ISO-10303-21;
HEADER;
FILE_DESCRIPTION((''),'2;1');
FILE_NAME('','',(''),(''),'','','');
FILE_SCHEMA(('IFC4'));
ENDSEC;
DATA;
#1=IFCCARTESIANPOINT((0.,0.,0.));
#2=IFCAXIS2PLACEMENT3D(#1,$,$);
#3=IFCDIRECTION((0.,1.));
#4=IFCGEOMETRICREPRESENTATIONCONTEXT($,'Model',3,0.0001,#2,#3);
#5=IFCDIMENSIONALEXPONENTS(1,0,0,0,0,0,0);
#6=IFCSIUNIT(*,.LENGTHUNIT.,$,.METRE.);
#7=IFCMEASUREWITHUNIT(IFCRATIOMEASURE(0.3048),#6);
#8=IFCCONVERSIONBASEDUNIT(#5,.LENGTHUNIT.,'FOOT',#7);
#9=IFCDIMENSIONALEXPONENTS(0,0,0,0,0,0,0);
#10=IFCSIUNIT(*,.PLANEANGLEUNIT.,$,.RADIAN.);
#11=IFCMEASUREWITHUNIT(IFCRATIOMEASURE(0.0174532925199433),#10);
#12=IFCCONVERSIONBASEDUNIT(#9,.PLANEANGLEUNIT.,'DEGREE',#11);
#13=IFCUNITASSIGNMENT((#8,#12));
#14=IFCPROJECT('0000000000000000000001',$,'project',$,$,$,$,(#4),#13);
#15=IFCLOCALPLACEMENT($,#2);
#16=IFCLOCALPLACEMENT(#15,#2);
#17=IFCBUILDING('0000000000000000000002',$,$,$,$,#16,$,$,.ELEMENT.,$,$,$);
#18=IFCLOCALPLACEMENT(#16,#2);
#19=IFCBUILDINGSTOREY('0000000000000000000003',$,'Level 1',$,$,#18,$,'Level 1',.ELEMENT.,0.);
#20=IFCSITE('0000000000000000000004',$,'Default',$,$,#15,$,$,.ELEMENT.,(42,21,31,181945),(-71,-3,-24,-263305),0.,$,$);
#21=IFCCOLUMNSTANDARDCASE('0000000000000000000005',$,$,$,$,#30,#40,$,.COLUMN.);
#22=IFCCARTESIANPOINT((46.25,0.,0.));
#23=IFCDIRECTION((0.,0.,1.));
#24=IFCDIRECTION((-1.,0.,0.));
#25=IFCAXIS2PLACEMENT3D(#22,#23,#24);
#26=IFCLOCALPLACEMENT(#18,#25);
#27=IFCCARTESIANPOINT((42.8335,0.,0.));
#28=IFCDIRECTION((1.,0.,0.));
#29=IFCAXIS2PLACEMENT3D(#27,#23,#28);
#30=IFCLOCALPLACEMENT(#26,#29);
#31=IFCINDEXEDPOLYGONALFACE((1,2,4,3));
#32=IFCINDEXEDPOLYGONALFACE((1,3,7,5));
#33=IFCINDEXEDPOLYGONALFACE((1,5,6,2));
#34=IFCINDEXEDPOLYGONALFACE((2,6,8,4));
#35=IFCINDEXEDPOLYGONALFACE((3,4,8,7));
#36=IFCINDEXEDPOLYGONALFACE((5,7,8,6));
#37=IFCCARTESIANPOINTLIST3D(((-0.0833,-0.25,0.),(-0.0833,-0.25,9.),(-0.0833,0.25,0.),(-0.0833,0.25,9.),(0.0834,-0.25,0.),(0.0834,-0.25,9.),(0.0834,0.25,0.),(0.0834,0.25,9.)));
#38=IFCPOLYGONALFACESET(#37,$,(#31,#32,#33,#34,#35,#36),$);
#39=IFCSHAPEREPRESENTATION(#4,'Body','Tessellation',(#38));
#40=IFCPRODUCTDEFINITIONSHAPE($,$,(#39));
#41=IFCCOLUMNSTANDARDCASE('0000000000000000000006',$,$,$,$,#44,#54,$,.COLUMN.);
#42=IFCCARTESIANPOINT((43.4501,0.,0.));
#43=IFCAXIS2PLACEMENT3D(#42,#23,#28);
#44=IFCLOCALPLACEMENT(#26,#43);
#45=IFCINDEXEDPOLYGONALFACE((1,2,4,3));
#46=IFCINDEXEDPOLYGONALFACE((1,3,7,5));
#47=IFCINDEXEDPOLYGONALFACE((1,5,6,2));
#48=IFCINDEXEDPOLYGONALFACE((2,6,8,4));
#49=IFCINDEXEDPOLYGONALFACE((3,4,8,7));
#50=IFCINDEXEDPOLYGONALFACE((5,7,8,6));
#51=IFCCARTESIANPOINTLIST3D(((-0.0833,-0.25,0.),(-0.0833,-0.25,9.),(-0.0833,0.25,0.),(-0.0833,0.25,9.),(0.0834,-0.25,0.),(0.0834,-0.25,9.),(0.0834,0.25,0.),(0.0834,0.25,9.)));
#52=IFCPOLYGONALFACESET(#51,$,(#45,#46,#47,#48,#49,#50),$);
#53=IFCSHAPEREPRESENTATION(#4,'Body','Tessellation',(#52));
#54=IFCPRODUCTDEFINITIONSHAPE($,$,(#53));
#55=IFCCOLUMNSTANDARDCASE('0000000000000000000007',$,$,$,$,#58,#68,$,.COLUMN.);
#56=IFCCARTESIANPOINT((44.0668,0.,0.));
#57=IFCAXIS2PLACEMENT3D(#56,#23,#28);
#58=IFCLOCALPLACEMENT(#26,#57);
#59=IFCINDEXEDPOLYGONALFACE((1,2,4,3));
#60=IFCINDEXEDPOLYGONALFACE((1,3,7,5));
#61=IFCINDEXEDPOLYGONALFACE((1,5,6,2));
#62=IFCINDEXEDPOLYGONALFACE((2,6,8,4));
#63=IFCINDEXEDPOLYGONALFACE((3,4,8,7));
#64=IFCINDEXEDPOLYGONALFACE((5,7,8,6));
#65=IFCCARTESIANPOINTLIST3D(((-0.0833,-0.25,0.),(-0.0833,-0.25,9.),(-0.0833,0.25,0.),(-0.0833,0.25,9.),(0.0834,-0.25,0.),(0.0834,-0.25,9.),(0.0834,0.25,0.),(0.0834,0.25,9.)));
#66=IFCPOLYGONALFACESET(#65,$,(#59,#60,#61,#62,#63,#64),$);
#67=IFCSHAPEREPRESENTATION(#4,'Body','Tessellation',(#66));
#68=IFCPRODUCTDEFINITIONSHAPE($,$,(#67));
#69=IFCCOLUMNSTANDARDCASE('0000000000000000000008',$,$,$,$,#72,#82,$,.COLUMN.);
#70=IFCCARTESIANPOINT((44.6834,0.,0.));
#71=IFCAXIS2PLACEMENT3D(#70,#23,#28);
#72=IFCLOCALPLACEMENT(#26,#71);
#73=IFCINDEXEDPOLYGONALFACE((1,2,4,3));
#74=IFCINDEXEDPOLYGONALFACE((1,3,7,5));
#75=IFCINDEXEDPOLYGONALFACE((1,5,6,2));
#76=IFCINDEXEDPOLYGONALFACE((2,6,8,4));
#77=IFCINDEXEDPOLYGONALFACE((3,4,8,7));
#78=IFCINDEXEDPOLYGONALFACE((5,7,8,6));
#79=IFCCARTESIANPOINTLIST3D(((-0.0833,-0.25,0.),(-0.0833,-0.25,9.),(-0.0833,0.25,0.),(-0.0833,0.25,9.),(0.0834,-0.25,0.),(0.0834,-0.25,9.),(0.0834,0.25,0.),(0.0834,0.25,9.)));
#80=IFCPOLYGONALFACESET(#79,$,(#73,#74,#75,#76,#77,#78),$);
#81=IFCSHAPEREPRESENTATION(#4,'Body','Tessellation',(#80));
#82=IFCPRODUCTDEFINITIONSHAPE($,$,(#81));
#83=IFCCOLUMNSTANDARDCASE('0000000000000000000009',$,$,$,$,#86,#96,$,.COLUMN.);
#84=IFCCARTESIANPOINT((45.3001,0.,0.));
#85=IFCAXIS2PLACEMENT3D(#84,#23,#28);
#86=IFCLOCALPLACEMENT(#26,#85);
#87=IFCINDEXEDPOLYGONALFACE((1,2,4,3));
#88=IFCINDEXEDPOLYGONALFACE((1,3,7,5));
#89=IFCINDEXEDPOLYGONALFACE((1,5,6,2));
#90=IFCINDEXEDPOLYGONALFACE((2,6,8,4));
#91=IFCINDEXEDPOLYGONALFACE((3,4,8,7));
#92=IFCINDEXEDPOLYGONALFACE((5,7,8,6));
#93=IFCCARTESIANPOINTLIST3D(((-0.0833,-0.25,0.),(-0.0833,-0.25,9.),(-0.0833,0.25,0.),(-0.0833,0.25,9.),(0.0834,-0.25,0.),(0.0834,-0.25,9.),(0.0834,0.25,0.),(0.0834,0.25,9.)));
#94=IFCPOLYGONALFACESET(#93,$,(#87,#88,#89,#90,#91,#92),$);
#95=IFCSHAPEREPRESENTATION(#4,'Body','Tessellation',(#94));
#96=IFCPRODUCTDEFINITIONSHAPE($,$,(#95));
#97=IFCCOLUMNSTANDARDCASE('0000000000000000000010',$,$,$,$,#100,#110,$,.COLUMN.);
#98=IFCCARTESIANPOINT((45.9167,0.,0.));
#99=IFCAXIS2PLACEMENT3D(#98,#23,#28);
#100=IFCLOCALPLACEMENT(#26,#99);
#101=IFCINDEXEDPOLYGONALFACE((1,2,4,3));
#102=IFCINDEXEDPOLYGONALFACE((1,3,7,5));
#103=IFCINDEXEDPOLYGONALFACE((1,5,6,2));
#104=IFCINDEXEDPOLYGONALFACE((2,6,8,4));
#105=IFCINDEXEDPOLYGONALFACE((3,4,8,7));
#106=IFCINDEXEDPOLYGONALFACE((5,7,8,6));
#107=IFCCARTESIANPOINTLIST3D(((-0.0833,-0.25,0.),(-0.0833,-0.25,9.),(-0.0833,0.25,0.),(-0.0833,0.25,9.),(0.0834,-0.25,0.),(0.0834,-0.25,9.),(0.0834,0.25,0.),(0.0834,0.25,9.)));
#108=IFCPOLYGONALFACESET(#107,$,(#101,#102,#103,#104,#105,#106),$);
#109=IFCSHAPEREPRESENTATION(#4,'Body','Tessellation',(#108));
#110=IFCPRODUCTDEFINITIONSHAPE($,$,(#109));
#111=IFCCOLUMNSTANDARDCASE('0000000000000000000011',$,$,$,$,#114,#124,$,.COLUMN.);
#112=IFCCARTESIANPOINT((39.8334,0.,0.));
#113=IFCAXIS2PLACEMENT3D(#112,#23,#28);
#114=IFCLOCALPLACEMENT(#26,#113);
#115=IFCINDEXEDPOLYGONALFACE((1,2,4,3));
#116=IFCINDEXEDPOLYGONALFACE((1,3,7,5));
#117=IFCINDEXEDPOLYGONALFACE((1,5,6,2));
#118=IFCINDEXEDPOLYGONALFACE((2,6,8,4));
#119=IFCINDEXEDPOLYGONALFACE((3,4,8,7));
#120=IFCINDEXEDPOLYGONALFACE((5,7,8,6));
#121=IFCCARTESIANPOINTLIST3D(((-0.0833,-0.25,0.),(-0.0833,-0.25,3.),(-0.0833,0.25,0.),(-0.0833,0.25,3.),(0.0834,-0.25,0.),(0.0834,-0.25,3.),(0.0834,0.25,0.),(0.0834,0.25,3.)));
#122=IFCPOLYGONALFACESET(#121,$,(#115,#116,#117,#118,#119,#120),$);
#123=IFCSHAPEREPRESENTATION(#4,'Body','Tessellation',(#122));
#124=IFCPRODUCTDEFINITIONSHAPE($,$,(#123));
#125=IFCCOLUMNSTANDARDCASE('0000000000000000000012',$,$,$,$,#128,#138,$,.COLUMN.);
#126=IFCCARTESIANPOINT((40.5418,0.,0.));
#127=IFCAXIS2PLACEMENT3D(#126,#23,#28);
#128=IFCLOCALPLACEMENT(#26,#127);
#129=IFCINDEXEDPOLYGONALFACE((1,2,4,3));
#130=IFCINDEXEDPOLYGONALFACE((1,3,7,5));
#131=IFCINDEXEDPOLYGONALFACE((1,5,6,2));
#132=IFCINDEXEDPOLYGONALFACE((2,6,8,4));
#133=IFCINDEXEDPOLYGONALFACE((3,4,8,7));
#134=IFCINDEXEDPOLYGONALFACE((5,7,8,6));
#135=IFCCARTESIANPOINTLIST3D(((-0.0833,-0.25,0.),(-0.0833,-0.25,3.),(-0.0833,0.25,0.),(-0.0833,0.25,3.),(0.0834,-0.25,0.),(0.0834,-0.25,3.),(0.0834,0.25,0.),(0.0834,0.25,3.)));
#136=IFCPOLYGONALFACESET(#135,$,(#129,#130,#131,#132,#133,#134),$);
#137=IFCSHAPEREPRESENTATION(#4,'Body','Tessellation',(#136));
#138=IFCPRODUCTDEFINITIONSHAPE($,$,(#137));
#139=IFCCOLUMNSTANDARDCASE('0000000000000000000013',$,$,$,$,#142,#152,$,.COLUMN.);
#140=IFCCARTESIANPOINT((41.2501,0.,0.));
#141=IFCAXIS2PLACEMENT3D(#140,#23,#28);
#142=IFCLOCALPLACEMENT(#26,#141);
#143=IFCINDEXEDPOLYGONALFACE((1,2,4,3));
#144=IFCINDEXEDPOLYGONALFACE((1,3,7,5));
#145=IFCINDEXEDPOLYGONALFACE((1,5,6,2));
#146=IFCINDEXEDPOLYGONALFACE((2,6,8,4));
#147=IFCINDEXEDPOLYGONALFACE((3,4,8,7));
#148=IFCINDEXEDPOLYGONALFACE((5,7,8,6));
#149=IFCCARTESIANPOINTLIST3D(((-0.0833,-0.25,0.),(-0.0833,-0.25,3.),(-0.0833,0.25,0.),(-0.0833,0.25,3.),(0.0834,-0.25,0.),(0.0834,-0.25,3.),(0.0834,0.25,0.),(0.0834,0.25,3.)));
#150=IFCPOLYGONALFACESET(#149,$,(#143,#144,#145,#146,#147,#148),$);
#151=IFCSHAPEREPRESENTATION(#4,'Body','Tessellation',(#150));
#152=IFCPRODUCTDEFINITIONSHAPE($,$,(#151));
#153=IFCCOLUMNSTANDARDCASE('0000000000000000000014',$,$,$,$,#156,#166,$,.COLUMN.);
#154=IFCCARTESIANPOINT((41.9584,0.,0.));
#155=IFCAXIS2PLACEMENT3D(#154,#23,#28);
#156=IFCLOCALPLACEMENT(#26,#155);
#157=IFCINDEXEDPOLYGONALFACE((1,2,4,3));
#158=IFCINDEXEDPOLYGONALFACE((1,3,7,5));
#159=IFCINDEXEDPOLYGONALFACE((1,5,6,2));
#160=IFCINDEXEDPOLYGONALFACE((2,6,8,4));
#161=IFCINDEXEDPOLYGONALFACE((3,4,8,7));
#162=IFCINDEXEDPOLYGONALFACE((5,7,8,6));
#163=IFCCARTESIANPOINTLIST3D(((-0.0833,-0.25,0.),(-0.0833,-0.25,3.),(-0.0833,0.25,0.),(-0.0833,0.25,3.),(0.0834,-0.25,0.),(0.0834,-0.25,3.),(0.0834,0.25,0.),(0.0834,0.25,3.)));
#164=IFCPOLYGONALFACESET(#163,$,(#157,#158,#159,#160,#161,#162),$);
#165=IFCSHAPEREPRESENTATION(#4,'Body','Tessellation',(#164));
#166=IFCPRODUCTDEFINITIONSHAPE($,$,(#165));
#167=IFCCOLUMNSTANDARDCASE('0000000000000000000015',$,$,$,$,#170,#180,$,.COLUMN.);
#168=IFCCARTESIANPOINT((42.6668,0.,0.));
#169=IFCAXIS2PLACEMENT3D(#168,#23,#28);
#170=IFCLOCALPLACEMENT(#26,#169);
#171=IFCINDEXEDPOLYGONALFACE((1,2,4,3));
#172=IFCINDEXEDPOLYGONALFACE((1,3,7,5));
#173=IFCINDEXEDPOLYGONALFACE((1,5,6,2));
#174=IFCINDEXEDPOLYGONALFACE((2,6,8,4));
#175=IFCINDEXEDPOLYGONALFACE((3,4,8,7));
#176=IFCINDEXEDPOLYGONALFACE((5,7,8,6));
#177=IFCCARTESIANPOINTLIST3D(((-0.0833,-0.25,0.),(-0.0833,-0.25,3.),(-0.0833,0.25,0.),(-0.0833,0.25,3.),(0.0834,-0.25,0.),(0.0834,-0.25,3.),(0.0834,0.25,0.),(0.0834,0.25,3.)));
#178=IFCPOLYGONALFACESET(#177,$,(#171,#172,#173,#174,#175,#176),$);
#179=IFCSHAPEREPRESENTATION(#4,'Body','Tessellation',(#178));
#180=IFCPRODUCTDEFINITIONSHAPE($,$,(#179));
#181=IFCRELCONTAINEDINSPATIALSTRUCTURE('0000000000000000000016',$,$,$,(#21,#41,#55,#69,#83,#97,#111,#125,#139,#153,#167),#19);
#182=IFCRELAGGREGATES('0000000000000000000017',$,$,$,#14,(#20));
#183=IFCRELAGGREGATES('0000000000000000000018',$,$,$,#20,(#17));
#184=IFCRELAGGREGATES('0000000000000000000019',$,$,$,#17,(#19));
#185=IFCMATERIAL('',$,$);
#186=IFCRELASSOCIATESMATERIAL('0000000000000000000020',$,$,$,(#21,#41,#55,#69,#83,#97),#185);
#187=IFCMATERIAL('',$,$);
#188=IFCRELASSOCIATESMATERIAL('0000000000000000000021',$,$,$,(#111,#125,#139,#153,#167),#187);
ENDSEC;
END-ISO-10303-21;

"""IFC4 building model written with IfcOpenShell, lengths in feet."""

from ifc_helpers import new_model, entity, si_unit, converted_unit, direction, frame, origin, place, context, project, spatial, rectangle, extrude, material, element, save


model = new_model("IFC4")

# Units and contexts
model_context = context("Model", 3, precision=0.0001, world=origin(), true_north=direction((0.0, 1.0)))
ifc_project = project(units=[converted_unit("LENGTHUNIT", "FOOT", entity("IfcRatioMeasure", 0.3048), si_unit("LENGTHUNIT", "METRE"), dimensions=[1, 0, 0, 0, 0, 0, 0]), converted_unit("PLANEANGLEUNIT", "DEGREE", entity("IfcRatioMeasure", 0.0174532925199433), si_unit("PLANEANGLEUNIT", "RADIAN"), dimensions=[0, 0, 0, 0, 0, 0, 0])], contexts=[model_context])

# Site, building, storey
site_placement = place(None, origin())
site = spatial("IfcSite", under=ifc_project, at=site_placement, Name="Default", CompositionType="ELEMENT", RefLatitude=(42, 21, 31, 181945), RefLongitude=(-71, -3, -24, -263305), RefElevation=0.0)
building_placement = place(site_placement, origin())
building = spatial("IfcBuilding", under=site, at=building_placement, CompositionType="ELEMENT")
storey_placement = place(building_placement, origin())
storey = spatial("IfcBuildingStorey", under=building, at=storey_placement, Name="Level 1", LongName="Level 1", CompositionType="ELEMENT", Elevation=0.0)

# Columns
ifc_material_1 = material(Name="")
ifc_material_2 = material(Name="")
placement_1 = place(storey_placement, frame((46.25, 0.0, 0.0), z_axis=(0.0, 0.0, 1.0), x_axis=(-1.0, 0.0, 0.0)))
for number, where, z_axis, x_axis in (
    (1, (42.8335, 0.0, 0.0), (0.0, 0.0, 1.0), (1.0, 0.0, 0.0)),
    (2, (43.4501, 0.0, 0.0), (0.0, 0.0, 1.0), (1.0, 0.0, 0.0)),
    (3, (44.0668, 0.0, 0.0), (0.0, 0.0, 1.0), (1.0, 0.0, 0.0)),
    (4, (44.6834, 0.0, 0.0), (0.0, 0.0, 1.0), (1.0, 0.0, 0.0)),
    (5, (45.3001, 0.0, 0.0), (0.0, 0.0, 1.0), (1.0, 0.0, 0.0)),
    (6, (45.9167, 0.0, 0.0), (0.0, 0.0, 1.0), (1.0, 0.0, 0.0)),
):
    element("IfcColumnStandardCase", number, at=place(placement_1, frame(where, z_axis=z_axis, x_axis=x_axis)), inside=storey, material=ifc_material_2, PredefinedType="COLUMN", context=model_context, shape_type="SweptSolid", body=[
        extrude(rectangle(XDim=0.1667, YDim=0.5), origin(), (0.0, 0.0, 1.0), 9.0),
    ])
for number, where, z_axis, x_axis in (
    (7, (39.8334, 0.0, 0.0), (0.0, 0.0, 1.0), (1.0, 0.0, 0.0)),
    (8, (40.5418, 0.0, 0.0), (0.0, 0.0, 1.0), (1.0, 0.0, 0.0)),
    (9, (41.2501, 0.0, 0.0), (0.0, 0.0, 1.0), (1.0, 0.0, 0.0)),
    (10, (41.9584, 0.0, 0.0), (0.0, 0.0, 1.0), (1.0, 0.0, 0.0)),
    (11, (42.6668, 0.0, 0.0), (0.0, 0.0, 1.0), (1.0, 0.0, 0.0)),
):
    element("IfcColumnStandardCase", number, at=place(placement_1, frame(where, z_axis=z_axis, x_axis=x_axis)), inside=storey, material=ifc_material_1, PredefinedType="COLUMN", context=model_context, shape_type="SweptSolid", body=[
        extrude(rectangle(XDim=0.1667, YDim=0.5), origin(), (0.0, 0.0, 1.0), 3.0),
    ])

save(model, "model.ifc")
